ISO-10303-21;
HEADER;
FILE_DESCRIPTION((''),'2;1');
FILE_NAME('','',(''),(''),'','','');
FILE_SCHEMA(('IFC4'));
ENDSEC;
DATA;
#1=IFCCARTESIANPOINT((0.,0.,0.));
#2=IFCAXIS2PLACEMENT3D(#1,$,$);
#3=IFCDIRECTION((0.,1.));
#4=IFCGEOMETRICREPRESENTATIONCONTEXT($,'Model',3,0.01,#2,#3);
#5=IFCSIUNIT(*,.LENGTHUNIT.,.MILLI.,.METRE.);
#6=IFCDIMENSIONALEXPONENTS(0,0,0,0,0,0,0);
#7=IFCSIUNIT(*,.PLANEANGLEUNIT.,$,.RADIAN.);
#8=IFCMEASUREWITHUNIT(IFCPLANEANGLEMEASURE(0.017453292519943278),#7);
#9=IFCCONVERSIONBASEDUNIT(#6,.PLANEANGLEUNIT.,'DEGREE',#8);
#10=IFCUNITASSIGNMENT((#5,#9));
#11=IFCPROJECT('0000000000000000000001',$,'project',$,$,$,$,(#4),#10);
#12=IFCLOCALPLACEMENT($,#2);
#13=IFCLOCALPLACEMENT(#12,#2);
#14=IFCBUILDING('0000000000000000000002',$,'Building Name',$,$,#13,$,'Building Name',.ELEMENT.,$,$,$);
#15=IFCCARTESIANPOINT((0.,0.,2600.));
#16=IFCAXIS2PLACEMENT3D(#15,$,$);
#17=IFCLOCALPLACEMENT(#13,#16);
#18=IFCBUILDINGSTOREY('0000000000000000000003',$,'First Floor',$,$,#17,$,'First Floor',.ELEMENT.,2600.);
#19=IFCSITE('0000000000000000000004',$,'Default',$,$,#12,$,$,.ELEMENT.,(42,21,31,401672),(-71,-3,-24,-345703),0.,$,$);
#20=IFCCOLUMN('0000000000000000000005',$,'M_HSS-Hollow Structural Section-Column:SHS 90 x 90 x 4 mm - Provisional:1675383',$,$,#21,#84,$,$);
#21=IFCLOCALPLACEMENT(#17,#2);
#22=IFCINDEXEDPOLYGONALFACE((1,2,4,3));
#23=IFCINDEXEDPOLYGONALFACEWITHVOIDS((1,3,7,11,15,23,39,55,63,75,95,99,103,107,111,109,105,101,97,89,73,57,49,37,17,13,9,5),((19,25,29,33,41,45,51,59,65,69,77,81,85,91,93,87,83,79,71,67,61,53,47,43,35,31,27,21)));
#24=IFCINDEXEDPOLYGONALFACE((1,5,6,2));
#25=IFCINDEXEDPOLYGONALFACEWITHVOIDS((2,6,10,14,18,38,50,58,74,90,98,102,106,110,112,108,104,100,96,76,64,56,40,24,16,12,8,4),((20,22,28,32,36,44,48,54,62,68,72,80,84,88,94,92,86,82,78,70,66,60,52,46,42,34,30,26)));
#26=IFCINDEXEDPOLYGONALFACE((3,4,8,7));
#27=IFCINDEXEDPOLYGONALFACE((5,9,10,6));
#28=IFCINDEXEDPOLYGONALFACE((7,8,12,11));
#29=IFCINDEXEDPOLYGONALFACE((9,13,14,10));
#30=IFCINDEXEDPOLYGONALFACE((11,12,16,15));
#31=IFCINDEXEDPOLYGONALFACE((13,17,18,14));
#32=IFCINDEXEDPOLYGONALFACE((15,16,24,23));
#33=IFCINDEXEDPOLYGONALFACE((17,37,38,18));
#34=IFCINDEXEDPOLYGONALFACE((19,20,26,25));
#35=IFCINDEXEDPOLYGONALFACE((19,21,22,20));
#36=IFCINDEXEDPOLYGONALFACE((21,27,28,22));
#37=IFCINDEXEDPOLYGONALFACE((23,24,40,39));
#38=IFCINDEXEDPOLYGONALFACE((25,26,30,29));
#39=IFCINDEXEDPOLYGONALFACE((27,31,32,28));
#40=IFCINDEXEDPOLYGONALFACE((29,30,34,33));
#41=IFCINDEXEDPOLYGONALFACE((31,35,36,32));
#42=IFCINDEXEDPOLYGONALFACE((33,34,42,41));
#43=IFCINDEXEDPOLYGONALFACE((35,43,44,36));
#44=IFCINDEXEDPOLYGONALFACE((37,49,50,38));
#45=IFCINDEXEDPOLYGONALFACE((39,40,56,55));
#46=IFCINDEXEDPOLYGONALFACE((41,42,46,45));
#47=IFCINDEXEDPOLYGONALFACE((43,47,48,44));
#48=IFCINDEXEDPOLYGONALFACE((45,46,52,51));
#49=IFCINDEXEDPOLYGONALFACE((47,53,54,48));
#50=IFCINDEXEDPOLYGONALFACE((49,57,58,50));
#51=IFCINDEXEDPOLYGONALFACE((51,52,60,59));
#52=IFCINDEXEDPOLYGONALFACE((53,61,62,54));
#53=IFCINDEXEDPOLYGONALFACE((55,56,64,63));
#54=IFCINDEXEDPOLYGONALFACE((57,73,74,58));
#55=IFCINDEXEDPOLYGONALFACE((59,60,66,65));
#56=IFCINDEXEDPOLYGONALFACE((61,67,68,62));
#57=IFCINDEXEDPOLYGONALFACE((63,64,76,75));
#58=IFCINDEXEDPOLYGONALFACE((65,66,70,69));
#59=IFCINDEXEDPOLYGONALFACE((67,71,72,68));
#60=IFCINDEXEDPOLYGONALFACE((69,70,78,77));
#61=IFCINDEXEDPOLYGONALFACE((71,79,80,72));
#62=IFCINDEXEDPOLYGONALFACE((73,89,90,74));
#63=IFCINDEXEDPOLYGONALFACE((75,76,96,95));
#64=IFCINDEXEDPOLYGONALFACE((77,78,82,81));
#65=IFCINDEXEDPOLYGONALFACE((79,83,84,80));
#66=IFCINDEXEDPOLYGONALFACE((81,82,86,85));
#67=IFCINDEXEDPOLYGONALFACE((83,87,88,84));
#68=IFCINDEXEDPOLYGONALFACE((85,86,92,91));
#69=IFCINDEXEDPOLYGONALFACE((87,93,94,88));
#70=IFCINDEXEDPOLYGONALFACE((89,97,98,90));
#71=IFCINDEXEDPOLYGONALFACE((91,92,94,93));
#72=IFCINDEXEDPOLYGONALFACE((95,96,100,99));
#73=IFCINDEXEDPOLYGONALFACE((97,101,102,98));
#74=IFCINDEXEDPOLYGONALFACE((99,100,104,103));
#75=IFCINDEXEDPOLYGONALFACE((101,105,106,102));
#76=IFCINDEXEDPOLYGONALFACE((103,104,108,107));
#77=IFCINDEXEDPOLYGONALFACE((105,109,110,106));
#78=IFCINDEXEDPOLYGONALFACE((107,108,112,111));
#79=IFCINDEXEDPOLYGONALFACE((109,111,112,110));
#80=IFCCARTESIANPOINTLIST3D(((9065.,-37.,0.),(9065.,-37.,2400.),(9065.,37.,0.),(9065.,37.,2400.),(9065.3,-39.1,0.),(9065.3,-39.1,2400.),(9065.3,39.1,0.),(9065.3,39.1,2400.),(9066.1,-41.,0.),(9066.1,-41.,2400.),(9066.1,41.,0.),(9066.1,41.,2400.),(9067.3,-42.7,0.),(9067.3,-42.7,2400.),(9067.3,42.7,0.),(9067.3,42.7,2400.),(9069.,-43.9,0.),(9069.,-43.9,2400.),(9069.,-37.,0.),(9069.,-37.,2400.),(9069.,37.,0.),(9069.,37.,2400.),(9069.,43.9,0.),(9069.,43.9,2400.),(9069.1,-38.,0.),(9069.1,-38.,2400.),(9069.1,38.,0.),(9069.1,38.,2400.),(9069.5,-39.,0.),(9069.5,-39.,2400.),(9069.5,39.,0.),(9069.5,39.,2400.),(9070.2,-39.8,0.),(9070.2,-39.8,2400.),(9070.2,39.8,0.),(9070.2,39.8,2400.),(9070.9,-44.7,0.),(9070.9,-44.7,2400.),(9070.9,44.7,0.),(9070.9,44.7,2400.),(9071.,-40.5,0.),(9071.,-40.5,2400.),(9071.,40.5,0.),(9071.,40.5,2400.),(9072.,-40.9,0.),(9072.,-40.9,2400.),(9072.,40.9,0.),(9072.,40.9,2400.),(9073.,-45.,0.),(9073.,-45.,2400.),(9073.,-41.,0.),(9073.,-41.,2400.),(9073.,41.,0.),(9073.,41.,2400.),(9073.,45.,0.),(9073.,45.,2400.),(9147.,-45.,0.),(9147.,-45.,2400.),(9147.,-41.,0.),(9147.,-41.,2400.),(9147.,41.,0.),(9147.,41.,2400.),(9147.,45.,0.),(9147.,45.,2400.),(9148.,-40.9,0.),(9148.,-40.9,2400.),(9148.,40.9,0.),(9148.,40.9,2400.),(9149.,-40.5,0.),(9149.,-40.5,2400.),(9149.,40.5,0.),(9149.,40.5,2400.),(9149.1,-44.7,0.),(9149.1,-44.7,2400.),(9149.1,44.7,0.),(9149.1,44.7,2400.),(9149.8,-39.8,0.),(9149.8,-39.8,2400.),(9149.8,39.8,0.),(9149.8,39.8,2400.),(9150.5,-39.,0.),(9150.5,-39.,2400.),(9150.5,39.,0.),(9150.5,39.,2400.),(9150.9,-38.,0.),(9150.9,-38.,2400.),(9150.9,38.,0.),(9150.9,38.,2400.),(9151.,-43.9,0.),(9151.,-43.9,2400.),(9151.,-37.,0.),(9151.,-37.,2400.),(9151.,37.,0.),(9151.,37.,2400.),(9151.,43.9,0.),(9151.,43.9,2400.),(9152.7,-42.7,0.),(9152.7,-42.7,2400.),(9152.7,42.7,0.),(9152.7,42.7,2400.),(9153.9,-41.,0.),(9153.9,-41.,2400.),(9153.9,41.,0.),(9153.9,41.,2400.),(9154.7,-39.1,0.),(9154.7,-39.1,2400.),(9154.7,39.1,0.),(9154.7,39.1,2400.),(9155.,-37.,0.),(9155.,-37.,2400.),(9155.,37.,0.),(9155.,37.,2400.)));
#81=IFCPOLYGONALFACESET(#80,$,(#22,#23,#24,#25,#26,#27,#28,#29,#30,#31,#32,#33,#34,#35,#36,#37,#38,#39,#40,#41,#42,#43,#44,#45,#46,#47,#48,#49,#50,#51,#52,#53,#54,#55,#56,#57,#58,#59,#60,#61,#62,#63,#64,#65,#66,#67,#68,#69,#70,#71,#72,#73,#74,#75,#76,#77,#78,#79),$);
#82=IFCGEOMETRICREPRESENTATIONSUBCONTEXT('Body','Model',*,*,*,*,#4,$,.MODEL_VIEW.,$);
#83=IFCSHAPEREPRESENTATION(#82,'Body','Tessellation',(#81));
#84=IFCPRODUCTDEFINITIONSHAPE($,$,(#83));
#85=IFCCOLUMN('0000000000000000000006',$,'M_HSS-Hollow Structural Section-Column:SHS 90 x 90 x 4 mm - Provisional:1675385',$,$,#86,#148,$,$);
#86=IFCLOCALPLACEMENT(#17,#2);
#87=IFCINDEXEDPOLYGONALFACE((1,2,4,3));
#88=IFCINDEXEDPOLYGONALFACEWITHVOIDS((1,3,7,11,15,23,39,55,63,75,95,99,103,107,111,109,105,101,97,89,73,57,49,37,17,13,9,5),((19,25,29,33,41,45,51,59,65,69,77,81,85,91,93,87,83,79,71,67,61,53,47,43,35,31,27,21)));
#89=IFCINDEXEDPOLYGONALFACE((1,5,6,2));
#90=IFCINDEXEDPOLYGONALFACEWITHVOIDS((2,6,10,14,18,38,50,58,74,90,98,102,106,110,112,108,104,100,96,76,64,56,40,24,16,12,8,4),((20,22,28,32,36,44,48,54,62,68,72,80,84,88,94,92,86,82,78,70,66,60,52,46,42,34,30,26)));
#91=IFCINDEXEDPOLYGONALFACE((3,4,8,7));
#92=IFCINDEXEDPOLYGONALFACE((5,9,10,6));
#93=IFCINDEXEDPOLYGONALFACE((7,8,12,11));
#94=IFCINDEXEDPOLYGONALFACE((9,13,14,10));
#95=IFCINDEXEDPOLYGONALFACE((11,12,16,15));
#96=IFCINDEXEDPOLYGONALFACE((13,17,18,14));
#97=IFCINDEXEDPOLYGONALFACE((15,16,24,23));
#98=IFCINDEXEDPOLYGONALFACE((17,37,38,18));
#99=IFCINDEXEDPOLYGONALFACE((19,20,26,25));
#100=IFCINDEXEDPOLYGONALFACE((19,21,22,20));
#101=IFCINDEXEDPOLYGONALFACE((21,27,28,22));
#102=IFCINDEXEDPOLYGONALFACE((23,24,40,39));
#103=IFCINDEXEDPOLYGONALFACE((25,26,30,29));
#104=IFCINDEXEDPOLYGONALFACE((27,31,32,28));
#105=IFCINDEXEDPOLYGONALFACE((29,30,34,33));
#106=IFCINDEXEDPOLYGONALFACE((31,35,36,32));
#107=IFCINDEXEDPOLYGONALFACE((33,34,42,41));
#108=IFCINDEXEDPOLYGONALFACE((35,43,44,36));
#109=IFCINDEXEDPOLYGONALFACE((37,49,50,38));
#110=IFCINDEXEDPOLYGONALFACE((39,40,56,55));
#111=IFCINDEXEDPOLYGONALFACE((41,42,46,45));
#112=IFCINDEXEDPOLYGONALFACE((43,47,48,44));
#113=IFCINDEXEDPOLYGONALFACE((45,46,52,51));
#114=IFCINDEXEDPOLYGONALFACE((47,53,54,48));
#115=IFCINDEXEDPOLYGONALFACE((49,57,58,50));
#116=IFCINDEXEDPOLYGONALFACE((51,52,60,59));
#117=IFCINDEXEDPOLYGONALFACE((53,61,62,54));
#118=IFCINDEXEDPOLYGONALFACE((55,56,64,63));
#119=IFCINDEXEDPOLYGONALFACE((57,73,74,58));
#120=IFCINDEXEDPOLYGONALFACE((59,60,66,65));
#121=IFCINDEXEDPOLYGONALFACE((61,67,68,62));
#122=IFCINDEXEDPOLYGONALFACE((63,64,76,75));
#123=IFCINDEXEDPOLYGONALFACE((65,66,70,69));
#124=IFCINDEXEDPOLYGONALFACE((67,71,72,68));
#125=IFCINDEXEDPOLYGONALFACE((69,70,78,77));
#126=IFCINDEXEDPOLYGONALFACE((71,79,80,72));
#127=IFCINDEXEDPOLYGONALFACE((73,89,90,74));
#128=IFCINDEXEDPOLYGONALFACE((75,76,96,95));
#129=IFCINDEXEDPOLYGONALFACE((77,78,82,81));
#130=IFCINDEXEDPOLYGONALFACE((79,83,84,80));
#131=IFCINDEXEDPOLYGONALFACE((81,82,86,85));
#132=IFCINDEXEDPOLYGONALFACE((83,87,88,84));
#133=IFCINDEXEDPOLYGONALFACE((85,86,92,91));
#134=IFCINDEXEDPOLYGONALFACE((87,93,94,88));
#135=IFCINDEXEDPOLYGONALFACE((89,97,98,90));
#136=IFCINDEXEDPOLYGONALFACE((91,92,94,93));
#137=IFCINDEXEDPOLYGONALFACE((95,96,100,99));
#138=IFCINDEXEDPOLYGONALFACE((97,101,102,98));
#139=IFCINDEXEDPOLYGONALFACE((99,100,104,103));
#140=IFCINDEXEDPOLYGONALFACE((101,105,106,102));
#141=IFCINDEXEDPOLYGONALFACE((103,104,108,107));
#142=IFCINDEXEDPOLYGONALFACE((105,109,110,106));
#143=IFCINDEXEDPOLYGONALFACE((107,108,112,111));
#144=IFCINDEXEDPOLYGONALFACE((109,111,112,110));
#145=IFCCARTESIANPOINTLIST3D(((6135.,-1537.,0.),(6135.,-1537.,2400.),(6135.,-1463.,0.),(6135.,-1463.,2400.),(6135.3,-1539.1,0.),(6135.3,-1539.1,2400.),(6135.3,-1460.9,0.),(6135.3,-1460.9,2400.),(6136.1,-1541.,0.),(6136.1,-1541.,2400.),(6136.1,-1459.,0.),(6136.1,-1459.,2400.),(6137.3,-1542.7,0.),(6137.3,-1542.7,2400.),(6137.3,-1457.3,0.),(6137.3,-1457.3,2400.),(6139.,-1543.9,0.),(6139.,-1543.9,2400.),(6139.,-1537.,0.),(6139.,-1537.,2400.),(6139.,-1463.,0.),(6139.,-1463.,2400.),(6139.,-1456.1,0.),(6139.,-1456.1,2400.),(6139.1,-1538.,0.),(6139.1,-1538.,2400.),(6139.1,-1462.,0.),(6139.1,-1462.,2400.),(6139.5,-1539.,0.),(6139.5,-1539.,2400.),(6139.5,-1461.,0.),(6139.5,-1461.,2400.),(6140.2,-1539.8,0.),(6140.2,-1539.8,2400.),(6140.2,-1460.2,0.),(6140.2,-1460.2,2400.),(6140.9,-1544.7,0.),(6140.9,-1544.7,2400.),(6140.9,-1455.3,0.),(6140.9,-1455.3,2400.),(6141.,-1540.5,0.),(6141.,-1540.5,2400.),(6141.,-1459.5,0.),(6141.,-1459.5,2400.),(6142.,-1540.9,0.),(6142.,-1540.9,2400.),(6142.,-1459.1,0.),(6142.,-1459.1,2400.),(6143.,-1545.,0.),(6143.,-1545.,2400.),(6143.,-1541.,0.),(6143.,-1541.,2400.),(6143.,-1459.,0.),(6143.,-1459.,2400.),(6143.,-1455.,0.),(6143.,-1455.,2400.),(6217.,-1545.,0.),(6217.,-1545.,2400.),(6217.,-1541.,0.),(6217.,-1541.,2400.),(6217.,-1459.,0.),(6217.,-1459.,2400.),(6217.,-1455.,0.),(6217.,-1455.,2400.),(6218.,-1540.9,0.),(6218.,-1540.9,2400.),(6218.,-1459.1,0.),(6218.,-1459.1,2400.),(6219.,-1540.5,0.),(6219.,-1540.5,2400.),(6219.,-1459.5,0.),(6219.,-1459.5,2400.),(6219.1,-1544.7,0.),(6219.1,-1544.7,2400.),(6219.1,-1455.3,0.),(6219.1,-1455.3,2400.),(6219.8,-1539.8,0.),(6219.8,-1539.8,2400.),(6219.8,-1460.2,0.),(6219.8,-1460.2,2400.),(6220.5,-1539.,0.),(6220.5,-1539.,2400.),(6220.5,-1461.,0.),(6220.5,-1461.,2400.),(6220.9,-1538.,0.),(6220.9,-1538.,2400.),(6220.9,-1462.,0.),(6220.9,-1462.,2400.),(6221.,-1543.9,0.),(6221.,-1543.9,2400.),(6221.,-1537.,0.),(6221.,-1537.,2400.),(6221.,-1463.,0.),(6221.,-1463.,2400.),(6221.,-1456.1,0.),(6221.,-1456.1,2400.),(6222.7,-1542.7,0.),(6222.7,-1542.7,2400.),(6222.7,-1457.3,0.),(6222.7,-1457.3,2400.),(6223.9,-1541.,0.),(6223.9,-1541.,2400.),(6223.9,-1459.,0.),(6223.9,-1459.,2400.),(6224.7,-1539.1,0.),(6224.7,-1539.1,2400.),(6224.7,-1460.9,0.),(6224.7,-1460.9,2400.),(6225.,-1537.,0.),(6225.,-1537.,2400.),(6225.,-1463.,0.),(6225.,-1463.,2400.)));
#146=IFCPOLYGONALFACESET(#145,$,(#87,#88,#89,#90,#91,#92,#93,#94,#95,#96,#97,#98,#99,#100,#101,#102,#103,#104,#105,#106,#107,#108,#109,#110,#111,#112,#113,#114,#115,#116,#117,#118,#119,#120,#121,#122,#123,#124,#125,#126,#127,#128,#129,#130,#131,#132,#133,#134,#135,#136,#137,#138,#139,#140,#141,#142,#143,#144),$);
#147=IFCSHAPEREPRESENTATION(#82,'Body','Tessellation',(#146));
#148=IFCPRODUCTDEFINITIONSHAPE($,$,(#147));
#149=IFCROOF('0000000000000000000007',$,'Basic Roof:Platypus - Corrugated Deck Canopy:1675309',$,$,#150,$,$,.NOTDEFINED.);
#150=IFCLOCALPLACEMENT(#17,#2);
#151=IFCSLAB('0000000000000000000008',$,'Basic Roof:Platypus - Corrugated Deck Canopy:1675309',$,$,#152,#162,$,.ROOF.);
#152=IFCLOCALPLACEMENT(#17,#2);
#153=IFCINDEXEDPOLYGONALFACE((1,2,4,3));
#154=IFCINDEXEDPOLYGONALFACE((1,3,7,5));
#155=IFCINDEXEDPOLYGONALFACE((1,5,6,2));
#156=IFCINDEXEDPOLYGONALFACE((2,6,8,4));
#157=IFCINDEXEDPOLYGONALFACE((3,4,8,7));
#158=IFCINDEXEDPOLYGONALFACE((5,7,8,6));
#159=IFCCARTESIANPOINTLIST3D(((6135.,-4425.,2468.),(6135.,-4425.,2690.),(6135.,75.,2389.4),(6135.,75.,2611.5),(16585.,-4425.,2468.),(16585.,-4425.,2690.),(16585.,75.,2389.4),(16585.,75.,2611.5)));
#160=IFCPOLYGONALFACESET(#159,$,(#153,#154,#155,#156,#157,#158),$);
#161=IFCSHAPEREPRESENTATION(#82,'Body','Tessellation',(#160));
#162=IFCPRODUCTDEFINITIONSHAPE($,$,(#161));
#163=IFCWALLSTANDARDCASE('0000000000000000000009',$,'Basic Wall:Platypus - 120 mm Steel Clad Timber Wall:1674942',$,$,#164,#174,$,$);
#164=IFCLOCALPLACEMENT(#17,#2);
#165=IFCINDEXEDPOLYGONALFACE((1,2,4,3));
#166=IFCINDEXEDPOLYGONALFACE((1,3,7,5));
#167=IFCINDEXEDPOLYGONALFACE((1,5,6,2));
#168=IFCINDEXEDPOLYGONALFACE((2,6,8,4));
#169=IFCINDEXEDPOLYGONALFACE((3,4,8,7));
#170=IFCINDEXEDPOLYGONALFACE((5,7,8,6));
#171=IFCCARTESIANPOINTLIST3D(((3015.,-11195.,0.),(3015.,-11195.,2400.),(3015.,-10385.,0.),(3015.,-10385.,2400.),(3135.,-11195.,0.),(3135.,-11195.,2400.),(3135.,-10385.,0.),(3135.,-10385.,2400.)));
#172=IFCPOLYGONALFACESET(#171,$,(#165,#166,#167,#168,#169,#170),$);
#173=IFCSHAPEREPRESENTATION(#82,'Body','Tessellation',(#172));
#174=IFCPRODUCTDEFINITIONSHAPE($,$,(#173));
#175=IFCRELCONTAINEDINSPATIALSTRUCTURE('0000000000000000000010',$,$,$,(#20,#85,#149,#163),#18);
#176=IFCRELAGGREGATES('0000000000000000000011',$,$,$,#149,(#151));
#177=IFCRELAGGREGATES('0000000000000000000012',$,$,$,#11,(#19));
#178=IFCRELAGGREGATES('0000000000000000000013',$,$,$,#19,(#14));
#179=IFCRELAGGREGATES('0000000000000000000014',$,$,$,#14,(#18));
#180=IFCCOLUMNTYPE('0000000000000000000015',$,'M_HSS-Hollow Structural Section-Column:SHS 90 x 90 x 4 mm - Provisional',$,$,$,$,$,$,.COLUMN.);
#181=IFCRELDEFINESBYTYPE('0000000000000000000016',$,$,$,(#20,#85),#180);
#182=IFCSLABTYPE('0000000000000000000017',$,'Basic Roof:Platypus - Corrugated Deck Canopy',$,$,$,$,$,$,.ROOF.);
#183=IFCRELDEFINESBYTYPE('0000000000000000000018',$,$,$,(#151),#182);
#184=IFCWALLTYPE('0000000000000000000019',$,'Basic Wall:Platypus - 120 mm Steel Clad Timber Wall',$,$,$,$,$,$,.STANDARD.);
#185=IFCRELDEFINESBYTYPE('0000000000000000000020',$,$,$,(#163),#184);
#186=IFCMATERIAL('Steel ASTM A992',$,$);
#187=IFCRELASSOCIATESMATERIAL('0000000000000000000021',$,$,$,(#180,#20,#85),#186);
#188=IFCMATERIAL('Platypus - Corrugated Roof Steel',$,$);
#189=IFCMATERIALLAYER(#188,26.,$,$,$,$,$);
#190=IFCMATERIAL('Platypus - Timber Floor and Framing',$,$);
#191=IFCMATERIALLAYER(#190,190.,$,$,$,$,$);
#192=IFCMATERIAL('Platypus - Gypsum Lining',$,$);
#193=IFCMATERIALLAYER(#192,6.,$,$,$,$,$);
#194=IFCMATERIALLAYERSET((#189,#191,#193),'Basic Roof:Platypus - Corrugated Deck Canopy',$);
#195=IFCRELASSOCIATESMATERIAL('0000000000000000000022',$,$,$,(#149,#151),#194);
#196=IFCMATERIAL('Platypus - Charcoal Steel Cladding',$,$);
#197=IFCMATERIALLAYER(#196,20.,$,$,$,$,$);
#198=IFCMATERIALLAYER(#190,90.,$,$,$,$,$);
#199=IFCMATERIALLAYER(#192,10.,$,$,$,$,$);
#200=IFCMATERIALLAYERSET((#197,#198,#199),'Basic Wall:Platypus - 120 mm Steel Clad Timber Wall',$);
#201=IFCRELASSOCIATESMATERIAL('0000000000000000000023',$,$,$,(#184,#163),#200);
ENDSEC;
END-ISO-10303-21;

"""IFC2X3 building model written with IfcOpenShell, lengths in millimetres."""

from ifc_helpers import new_model, entity, si_unit, converted_unit, direction, frame, frame_2d, origin, place, context, subcontext, project, spatial, polyline, circle_curve, parameter, trimmed, segment, composite_curve, rectangle, outline, extrude, source, transform, mapped, material, layer, layer_set, layer_usage, type_object, type_shapes, element, aggregate, save


model = new_model("IFC2X3")

# Units and contexts
model_context = context("Model", 3, precision=0.01, world=origin(), true_north=direction((0.0, 1.0)))
body_context = subcontext(model_context, "Body", "Model", "MODEL_VIEW")
ifc_project = project(units=[si_unit("LENGTHUNIT", "METRE", prefix="MILLI"), converted_unit("PLANEANGLEUNIT", "DEGREE", entity("IfcPlaneAngleMeasure", 0.017453292519943278), si_unit("PLANEANGLEUNIT", "RADIAN"), dimensions=[0, 0, 0, 0, 0, 0, 0])], contexts=[model_context])

# Site, building, storey
site_placement = place(None, origin())
site = spatial("IfcSite", under=ifc_project, at=site_placement, Name="Default", CompositionType="ELEMENT", RefLatitude=(42, 21, 31, 401672), RefLongitude=(-71, -3, -24, -345703), RefElevation=0.0)
building_placement = place(site_placement, origin())
building = spatial("IfcBuilding", under=site, at=building_placement, Name="Building Name", LongName="Building Name", CompositionType="ELEMENT")
storey_placement = place(building_placement, frame((0.0, 0.0, 2600.0)))
storey = spatial("IfcBuildingStorey", under=building, at=storey_placement, Name="First Floor", LongName="First Floor", CompositionType="ELEMENT", Elevation=2600.0)

# Columns
ifc_material_1 = material(Name="Steel ASTM A992")
column_type = type_object("IfcColumnType", Name="M_HSS-Hollow Structural Section-Column:SHS 90 x 90 x 4 mm - Provisional", PredefinedType="COLUMN", material=ifc_material_1)
shared_shape_1 = source(origin(), body_context, "Body", "SweptSolid", [
    extrude(outline(composite_curve([segment(polyline([(-37.0, -45.0), (37.0, -45.0)]), True, "CONTINUOUS"), segment(trimmed(circle_curve(frame_2d((37.0, -37.0), x_axis=(-1.0, 0.0)), 8.0), [parameter(90.0)], [parameter(180.0)], True, "PARAMETER"), True, "CONTINUOUS"), segment(polyline([(45.0, -37.0), (45.0, 37.0)]), True, "CONTINUOUS"), segment(trimmed(circle_curve(frame_2d((37.0, 37.0), x_axis=(-1.0, 0.0)), 8.0), [parameter(180.0)], [parameter(270.0)], True, "PARAMETER"), True, "CONTINUOUS"), segment(polyline([(37.0, 45.0), (-37.0, 45.0)]), True, "CONTINUOUS"), segment(trimmed(circle_curve(frame_2d((-37.0, 37.0), x_axis=(-1.0, 0.0)), 8.0), [parameter(270.0)], [parameter(360.0)], True, "PARAMETER"), True, "CONTINUOUS"), segment(polyline([(-45.0, 37.0), (-45.0, -37.0)]), True, "CONTINUOUS"), segment(trimmed(circle_curve(frame_2d((-37.0, -37.0), x_axis=(-1.0, 0.0)), 8.0), [parameter(360.0)], [parameter(90.0)], True, "PARAMETER"), True, "CONTINUOUS")], self_intersect=False), holes=[composite_curve([segment(trimmed(circle_curve(frame_2d((-37.0, -37.0), x_axis=(-1.0, 0.0)), 4.0), [parameter(0.0)], [parameter(90.0)], True, "PARAMETER"), False, "CONTINUOUS"), segment(polyline([(-41.0, -37.0), (-41.0, 37.0)]), True, "CONTINUOUS"), segment(trimmed(circle_curve(frame_2d((-37.0, 37.0), x_axis=(-1.0, 0.0)), 4.0), [parameter(270.0)], [parameter(0.0)], True, "PARAMETER"), False, "CONTINUOUS"), segment(polyline([(-37.0, 41.0), (37.0, 41.0)]), True, "CONTINUOUS"), segment(trimmed(circle_curve(frame_2d((37.0, 37.0), x_axis=(-1.0, 0.0)), 4.0), [parameter(180.0)], [parameter(270.0)], True, "PARAMETER"), False, "CONTINUOUS"), segment(polyline([(41.0, 37.0), (41.0, -37.0)]), True, "CONTINUOUS"), segment(trimmed(circle_curve(frame_2d((37.0, -37.0), x_axis=(-1.0, 0.0)), 4.0), [parameter(90.0)], [parameter(180.0)], True, "PARAMETER"), False, "CONTINUOUS"), segment(polyline([(37.0, -41.0), (-37.0, -41.0)]), True, "CONTINUOUS")], self_intersect=False)]), frame((0.0, 0.0, 2600.0), z_axis=(0.0, 0.0, 1.0), x_axis=(-1.0, 0.0, 0.0)), (0.0, 0.0, 1.0), 2400.0),
])
type_shapes(column_type, [shared_shape_1])
for number, where, name in (
    (1, (9110.0, 0.0, -2600.0), "M_HSS-Hollow Structural Section-Column:SHS 90 x 90 x 4 mm - Provisional:1675383"),
    (2, (6180.0, -1500.0, -2600.0), "M_HSS-Hollow Structural Section-Column:SHS 90 x 90 x 4 mm - Provisional:1675385"),
):
    element("IfcColumn", number, at=place(storey_placement, frame(where)), inside=storey, type_object=column_type, material=ifc_material_1, Name=name, context=body_context, shape_type="MappedRepresentation", body=[
        mapped(shared_shape_1, transform((0.0, 0.0, 0.0), scale=1.0)),
    ])

# Roof, slab
ifc_material_2 = material(Name="Platypus - Corrugated Roof Steel")
ifc_layer_1 = layer(ifc_material_2, 26.0)
ifc_material_3 = material(Name="Platypus - Timber Floor and Framing")
ifc_layer_2 = layer(ifc_material_3, 190.0)
ifc_material_4 = material(Name="Platypus - Gypsum Lining")
ifc_layer_3 = layer(ifc_material_4, 6.0)
ifc_layer_set_1 = layer_set([ifc_layer_1, ifc_layer_2, ifc_layer_3], Name="Basic Roof:Platypus - Corrugated Deck Canopy")
roof_placement = place(storey_placement, frame((6135.0, -4425.0, 2389.4)))
roof = element("IfcRoof", 3, at=roof_placement, inside=storey, material=ifc_layer_set_1, Name="Basic Roof:Platypus - Corrugated Deck Canopy:1675309", ShapeType="NOTDEFINED")
slab_type = type_object("IfcSlabType", Name="Basic Roof:Platypus - Corrugated Deck Canopy", PredefinedType="ROOF")
slab_placement = place(roof_placement, origin())
slab = element("IfcSlab", 4, at=slab_placement, type_object=slab_type, material=ifc_layer_set_1, Name="Basic Roof:Platypus - Corrugated Deck Canopy:1675309", PredefinedType="ROOF", context=body_context, shape_type="SweptSolid", body=[
    extrude(rectangle(XDim=4500.7, YDim=10450.0, at=frame_2d((0.0, 0.0), x_axis=(0.0, 1.0))), frame((5225.0, 2250.0, 39.3), z_axis=(0.0, 0.017451, 0.999848), x_axis=(1.0, 0.0, 0.0)), (0.0, -0.017451, 0.999848), 222.0),
])
aggregate(roof, [slab])

# Wall
ifc_material_5 = material(Name="Platypus - Charcoal Steel Cladding")
ifc_layer_4 = layer(ifc_material_5, 20.0)
ifc_layer_5 = layer(ifc_material_3, 90.0)
ifc_layer_6 = layer(ifc_material_4, 10.0)
ifc_layer_set_2 = layer_set([ifc_layer_4, ifc_layer_5, ifc_layer_6], Name="Basic Wall:Platypus - 120 mm Steel Clad Timber Wall")
ifc_layer_usage_1 = layer_usage(ifc_layer_set_2, "AXIS2", "POSITIVE", -60.0)
wall_type_1 = type_object("IfcWallType", Name="Basic Wall:Platypus - 120 mm Steel Clad Timber Wall", PredefinedType="STANDARD", material=ifc_layer_set_2)
wall_1_placement = place(storey_placement, frame((3075.0, -11195.0, 0.0), z_axis=(0.0, 0.0, 1.0), x_axis=(0.0, 1.0, 0.0)))
element("IfcWallStandardCase", 5, at=wall_1_placement, inside=storey, type_object=wall_type_1, material=ifc_layer_usage_1, Name="Basic Wall:Platypus - 120 mm Steel Clad Timber Wall:1674942", context=body_context, shape_type="SweptSolid", body=[
    extrude(rectangle(XDim=810.0, YDim=120.0, at=frame_2d((405.0, 0.0), x_axis=(-1.0, 0.0))), origin(), (0.0, 0.0, 1.0), 2400.0),
])

save(model, "model.ifc")
